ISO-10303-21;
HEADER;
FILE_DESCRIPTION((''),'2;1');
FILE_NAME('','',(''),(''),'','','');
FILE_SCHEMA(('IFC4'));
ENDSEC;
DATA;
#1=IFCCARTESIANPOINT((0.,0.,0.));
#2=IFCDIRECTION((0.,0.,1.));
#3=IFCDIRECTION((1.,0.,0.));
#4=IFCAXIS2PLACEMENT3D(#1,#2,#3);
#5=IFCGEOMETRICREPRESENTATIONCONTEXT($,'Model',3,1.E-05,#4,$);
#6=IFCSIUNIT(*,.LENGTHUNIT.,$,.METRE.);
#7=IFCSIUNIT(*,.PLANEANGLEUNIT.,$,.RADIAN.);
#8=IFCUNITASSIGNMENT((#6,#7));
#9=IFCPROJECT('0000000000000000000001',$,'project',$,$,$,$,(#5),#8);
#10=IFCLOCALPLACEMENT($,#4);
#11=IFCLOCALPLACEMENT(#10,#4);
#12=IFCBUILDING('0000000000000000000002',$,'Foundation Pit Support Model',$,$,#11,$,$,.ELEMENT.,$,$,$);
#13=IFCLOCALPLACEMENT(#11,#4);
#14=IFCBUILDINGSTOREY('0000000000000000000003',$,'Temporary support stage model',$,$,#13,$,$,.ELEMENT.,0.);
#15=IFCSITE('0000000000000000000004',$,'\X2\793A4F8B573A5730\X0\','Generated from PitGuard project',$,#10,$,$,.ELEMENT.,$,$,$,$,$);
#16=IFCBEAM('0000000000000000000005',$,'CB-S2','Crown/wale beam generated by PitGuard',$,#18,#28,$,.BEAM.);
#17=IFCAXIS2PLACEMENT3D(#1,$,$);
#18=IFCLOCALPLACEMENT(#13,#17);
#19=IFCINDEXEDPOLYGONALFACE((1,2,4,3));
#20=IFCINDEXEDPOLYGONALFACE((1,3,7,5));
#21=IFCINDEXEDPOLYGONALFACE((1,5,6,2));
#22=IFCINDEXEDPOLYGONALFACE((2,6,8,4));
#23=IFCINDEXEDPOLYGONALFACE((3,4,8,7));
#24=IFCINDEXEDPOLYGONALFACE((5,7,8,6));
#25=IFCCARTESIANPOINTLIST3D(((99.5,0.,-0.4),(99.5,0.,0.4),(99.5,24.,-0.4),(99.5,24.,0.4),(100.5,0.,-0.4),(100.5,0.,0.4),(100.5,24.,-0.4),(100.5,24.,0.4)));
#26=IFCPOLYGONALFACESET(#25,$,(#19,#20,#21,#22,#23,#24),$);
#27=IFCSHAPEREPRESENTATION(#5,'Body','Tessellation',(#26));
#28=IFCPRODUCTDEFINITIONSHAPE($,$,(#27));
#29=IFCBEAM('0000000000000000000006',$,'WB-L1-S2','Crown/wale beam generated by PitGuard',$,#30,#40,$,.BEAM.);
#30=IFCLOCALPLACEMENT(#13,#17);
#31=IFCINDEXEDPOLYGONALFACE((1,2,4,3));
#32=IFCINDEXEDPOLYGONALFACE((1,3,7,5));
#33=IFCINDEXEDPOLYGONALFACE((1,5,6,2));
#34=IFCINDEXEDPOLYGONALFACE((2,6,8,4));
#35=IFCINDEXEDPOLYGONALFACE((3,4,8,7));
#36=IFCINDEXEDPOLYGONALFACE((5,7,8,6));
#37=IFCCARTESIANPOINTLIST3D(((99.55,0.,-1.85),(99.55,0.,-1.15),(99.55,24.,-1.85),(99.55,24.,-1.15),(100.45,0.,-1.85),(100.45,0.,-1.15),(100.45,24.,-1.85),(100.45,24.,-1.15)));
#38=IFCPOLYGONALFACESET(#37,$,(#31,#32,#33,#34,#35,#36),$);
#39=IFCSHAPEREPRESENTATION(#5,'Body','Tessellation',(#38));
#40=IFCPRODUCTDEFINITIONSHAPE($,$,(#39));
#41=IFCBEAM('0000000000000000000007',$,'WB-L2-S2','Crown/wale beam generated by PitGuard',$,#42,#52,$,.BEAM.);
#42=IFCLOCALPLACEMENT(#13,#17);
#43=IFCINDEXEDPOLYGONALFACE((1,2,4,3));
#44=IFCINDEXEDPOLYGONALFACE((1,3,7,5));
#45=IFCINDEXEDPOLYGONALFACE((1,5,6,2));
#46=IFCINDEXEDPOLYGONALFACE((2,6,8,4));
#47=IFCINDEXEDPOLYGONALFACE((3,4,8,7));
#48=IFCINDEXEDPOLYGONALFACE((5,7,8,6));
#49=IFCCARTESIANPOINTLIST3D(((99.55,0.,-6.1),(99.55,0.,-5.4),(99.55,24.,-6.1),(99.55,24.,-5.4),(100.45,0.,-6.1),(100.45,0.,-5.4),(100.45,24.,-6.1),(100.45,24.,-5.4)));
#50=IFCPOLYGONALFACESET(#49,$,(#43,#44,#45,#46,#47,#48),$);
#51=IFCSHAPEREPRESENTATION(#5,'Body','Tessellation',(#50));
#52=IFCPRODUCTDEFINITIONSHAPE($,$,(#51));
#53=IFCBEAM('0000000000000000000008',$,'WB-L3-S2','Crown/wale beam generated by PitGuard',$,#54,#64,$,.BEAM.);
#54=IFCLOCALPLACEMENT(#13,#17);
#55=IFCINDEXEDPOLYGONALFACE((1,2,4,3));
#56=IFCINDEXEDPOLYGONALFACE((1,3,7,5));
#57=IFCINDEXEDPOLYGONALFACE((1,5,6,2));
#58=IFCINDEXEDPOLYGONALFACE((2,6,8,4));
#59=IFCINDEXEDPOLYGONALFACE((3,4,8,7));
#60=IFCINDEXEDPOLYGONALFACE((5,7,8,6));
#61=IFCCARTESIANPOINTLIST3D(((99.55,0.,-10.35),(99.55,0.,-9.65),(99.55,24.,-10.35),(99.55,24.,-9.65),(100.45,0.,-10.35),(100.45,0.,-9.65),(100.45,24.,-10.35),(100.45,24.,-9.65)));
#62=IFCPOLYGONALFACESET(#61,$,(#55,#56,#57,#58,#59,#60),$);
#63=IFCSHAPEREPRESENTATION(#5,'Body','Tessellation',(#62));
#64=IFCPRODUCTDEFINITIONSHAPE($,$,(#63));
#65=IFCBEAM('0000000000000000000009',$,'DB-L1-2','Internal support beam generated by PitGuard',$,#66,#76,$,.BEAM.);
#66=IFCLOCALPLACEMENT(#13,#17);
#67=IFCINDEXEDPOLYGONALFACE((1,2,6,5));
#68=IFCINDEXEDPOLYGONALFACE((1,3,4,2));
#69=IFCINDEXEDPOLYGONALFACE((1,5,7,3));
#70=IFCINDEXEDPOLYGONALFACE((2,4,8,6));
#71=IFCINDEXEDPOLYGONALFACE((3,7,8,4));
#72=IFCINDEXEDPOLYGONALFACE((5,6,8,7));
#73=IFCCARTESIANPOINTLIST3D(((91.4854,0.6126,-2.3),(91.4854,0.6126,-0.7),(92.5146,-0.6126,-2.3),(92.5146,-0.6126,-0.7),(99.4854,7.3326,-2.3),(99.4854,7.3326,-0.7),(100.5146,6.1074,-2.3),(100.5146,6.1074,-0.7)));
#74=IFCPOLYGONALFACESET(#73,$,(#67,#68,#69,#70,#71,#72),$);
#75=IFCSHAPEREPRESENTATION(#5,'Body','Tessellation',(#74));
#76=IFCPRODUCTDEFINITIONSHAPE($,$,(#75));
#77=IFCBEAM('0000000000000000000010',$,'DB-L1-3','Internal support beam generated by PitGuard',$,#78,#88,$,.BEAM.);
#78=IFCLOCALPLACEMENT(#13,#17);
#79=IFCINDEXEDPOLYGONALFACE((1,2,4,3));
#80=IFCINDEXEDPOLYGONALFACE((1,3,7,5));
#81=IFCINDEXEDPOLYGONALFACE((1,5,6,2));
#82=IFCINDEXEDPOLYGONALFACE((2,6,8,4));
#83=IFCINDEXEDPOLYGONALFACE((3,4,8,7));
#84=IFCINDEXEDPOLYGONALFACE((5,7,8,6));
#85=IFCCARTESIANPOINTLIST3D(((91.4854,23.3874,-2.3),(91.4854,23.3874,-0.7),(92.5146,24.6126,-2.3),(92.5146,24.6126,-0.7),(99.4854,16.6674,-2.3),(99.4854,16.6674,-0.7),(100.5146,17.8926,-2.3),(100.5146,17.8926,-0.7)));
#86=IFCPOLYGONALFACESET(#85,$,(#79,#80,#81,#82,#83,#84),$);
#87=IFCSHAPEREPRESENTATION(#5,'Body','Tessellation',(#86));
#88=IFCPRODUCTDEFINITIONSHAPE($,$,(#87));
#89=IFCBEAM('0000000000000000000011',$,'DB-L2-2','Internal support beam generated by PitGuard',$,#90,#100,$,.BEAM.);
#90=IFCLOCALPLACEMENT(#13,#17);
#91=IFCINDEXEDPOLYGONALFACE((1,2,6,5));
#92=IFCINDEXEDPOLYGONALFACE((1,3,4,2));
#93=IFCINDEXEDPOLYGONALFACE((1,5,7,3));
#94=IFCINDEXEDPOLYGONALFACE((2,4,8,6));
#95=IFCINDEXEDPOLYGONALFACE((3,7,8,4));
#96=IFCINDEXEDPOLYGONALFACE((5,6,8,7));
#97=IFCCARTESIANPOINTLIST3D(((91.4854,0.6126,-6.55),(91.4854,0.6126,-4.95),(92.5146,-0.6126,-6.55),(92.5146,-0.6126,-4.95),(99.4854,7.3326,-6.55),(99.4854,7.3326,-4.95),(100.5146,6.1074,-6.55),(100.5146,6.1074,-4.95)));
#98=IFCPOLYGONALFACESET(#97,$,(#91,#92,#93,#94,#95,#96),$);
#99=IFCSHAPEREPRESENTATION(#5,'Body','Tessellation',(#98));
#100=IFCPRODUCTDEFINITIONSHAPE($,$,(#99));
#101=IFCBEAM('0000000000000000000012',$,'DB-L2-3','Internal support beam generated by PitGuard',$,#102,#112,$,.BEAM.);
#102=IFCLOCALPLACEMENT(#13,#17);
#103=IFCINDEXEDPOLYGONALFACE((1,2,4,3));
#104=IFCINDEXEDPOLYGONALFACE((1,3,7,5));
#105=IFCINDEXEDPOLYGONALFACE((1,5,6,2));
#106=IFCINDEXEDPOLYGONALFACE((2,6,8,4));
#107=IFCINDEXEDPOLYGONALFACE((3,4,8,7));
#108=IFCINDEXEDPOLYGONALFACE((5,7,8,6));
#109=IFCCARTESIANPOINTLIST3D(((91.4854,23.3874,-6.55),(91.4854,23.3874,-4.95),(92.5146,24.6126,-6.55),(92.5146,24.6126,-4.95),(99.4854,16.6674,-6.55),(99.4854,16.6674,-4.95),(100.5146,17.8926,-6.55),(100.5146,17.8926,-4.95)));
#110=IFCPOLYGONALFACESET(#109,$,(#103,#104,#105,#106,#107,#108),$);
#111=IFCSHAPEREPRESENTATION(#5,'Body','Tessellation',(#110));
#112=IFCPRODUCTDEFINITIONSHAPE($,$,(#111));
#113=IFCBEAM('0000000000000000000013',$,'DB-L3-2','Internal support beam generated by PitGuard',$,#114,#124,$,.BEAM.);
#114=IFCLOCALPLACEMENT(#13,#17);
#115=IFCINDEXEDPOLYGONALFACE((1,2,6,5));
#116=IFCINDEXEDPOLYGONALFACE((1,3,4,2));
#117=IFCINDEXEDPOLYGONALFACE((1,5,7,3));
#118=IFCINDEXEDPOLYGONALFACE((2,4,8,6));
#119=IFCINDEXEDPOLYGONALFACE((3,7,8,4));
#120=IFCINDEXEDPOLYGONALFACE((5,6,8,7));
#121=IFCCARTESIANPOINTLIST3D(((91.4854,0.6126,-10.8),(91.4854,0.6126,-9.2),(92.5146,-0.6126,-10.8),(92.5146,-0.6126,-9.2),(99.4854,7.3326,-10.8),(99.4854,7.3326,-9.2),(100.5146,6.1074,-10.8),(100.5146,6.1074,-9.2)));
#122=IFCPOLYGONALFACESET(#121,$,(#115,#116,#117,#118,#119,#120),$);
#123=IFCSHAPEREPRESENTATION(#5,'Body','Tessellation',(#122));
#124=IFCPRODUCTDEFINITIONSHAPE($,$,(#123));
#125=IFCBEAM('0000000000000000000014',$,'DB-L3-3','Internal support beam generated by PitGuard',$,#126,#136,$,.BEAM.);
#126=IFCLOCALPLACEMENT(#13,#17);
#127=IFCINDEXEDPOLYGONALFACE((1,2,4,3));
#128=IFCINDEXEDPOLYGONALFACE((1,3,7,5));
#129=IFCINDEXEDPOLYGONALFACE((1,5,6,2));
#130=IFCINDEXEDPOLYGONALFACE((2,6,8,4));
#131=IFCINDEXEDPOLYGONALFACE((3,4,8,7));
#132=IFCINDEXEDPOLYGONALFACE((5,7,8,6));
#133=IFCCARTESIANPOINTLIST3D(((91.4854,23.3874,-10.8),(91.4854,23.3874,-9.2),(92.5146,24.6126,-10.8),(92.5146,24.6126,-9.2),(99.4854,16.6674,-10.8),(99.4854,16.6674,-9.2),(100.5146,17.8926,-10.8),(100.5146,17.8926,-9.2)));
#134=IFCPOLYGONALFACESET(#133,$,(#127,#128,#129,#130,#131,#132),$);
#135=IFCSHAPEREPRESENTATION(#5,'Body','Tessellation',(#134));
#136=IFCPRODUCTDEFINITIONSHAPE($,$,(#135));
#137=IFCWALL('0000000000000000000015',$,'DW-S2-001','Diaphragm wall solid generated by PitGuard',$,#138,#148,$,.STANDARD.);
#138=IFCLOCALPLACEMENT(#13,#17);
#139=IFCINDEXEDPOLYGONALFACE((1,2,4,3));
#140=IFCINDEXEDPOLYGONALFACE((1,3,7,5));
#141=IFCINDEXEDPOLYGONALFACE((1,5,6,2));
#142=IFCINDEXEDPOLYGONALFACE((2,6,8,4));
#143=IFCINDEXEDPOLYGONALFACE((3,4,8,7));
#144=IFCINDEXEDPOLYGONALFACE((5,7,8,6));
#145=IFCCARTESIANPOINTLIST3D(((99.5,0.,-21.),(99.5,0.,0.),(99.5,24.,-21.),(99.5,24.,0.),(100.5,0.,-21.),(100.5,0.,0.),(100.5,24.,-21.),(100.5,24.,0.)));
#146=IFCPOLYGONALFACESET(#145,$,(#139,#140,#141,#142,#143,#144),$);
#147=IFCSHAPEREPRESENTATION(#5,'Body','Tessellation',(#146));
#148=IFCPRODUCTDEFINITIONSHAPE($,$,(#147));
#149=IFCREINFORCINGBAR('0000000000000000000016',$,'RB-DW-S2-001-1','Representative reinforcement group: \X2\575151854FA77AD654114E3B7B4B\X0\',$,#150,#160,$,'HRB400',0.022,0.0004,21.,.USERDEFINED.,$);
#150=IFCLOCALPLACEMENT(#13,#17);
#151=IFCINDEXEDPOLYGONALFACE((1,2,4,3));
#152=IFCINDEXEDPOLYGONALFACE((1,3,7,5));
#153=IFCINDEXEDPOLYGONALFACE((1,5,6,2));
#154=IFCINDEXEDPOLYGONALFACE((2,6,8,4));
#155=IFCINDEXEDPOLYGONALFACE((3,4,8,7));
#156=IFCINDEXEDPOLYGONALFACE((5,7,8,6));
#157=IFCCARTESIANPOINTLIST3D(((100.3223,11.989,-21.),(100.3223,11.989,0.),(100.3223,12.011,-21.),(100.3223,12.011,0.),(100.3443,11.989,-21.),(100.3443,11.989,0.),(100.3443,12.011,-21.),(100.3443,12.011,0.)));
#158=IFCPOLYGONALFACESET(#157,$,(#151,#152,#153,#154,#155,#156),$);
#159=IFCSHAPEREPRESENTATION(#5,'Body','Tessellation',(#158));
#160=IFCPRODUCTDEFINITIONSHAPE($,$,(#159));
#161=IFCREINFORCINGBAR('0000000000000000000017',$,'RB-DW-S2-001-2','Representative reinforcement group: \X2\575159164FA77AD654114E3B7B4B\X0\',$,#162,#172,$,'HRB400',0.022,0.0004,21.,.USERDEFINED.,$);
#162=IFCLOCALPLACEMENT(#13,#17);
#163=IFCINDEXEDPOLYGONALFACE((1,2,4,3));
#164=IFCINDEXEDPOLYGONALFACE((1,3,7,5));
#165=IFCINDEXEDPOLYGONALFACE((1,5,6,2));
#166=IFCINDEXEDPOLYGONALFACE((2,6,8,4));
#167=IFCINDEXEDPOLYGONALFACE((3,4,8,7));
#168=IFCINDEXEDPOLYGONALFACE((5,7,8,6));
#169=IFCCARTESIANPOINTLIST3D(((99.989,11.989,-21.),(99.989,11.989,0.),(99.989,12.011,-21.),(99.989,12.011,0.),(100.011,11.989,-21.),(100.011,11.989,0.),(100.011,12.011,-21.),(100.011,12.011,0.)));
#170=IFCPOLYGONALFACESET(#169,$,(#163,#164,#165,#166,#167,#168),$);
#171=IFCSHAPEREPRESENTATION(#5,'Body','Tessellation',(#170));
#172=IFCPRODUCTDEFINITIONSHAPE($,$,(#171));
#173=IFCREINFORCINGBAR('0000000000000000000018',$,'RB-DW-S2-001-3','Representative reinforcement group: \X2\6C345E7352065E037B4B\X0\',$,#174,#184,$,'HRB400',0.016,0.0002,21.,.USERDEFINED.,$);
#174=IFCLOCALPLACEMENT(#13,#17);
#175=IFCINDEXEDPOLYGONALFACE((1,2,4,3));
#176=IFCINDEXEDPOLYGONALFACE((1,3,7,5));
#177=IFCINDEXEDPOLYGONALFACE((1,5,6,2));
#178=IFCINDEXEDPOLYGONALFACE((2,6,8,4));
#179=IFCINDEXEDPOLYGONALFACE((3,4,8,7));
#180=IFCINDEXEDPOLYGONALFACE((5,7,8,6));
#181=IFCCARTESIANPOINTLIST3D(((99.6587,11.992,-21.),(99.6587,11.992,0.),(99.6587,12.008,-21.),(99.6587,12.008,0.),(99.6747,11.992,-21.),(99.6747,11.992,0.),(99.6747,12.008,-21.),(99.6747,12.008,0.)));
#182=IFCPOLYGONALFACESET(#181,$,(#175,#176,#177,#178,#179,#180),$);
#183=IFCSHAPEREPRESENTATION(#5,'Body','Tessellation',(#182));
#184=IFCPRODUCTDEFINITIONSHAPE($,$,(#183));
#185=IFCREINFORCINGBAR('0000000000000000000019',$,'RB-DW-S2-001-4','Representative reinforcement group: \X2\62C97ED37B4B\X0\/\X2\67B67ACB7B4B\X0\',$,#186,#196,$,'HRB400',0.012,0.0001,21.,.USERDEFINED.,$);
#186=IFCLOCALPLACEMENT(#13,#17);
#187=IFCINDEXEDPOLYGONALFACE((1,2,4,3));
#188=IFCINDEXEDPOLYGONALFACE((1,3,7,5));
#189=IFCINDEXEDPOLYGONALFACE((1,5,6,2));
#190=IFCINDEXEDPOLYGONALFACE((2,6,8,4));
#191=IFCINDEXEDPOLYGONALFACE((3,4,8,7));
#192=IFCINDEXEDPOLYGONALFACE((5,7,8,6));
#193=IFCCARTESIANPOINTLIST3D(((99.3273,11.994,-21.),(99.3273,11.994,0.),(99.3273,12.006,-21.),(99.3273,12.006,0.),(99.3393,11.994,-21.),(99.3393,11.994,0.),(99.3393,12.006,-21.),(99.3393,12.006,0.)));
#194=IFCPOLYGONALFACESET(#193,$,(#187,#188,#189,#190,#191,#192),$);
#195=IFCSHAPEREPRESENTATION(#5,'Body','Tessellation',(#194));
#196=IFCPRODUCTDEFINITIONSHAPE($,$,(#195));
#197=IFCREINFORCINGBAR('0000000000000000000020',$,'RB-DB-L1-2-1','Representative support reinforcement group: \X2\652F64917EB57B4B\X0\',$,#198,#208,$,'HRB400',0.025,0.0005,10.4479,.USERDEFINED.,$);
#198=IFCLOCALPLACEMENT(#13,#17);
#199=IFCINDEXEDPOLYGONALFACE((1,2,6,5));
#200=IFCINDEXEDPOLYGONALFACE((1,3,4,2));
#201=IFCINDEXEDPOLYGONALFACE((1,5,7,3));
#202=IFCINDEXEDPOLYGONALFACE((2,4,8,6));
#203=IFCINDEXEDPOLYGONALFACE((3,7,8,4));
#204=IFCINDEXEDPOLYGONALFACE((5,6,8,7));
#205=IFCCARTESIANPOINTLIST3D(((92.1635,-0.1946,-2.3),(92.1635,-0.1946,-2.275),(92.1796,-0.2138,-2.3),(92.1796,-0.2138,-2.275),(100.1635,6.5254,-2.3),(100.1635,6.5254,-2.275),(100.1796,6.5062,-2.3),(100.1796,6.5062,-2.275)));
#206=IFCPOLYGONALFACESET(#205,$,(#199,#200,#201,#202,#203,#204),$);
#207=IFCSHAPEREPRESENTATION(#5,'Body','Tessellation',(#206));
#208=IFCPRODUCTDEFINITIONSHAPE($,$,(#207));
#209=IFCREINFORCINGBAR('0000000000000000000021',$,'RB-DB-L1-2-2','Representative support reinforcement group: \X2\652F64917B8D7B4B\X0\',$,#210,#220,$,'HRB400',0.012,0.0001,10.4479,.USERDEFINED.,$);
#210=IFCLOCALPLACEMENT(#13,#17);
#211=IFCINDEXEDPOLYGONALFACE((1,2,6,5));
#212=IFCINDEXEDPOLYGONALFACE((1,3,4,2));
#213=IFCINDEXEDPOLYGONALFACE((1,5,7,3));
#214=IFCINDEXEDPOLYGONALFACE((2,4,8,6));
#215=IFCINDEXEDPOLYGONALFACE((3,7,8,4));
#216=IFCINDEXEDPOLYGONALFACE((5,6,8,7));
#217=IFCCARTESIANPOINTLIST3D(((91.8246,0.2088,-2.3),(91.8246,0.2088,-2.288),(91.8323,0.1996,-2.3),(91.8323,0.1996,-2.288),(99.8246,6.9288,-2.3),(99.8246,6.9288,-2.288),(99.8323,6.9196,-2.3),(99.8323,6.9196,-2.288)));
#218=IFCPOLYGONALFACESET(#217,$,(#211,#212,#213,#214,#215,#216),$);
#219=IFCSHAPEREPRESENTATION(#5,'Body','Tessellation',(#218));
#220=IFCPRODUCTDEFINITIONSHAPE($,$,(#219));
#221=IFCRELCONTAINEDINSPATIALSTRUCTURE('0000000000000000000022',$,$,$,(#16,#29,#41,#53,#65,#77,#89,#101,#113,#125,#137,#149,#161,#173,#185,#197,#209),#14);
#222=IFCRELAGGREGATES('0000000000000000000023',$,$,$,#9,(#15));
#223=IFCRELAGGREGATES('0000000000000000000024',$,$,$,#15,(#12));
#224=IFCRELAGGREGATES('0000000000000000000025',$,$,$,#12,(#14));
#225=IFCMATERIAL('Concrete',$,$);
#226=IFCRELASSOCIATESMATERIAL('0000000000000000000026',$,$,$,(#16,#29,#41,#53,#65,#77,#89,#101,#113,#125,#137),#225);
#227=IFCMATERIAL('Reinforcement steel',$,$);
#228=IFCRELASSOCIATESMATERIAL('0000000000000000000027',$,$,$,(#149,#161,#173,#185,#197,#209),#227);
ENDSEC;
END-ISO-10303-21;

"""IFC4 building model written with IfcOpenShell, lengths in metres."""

from ifc_helpers import new_model, si_unit, frame, origin_with_axes, origin_2d, place, context, project, spatial, rectangle, extrude, material, element, save


model = new_model("IFC4")

# Units and contexts
model_context = context("Model", 3, precision=1e-05, world=origin_with_axes())
ifc_project = project(units=[si_unit("LENGTHUNIT", "METRE"), si_unit("PLANEANGLEUNIT", "RADIAN")], contexts=[model_context])

# Site, building, storey
site_placement = place(None, origin_with_axes())
site = spatial("IfcSite", under=ifc_project, at=site_placement, Name="示例场地", Description="Generated from PitGuard project", CompositionType="ELEMENT")
building_placement = place(site_placement, origin_with_axes())
building = spatial("IfcBuilding", under=site, at=building_placement, Name="Foundation Pit Support Model", CompositionType="ELEMENT")
storey_placement = place(building_placement, origin_with_axes())
storey = spatial("IfcBuildingStorey", under=building, at=storey_placement, Name="Temporary support stage model", CompositionType="ELEMENT", Elevation=0.0)

# Beams
ifc_material_1 = material(Name="Concrete")
beam_placement = place(storey_placement, frame((100.0, 12.0, -0.4), z_axis=(0.0, 0.0, 1.0), x_axis=(0.0, 1.0, 0.0)))
element("IfcBeam", 1, at=beam_placement, inside=storey, material=ifc_material_1, Name="CB-S2", Description="Crown/wale beam generated by PitGuard", PredefinedType="BEAM", context=model_context, shape_type="SweptSolid", body=[
    extrude(rectangle(XDim=24.0, YDim=1.0, at=origin_2d()), origin_with_axes(), (0.0, 0.0, 1.0), 0.8),
])
for number, where, z_axis, x_axis, name in (
    (2, (100.0, 12.0, -1.85), (0.0, 0.0, 1.0), (0.0, 1.0, 0.0), "WB-L1-S2"),
    (3, (100.0, 12.0, -6.1), (0.0, 0.0, 1.0), (0.0, 1.0, 0.0), "WB-L2-S2"),
    (4, (100.0, 12.0, -10.35), (0.0, 0.0, 1.0), (0.0, 1.0, 0.0), "WB-L3-S2"),
):
    element("IfcBeam", number, at=place(storey_placement, frame(where, z_axis=z_axis, x_axis=x_axis)), inside=storey, material=ifc_material_1, Name=name, Description="Crown/wale beam generated by PitGuard", PredefinedType="BEAM", context=model_context, shape_type="SweptSolid", body=[
        extrude(rectangle(XDim=24.0, YDim=0.9, at=origin_2d()), origin_with_axes(), (0.0, 0.0, 1.0), 0.7),
    ])
for number, where, z_axis, x_axis, name in (
    (5, (96.0, 3.36, -2.3), (0.0, 0.0, 1.0), (0.765705, 0.643192, 0.0), "DB-L1-2"),
    (6, (96.0, 20.64, -2.3), (0.0, 0.0, 1.0), (0.765705, -0.643192, 0.0), "DB-L1-3"),
    (7, (96.0, 3.36, -6.55), (0.0, 0.0, 1.0), (0.765705, 0.643192, 0.0), "DB-L2-2"),
    (8, (96.0, 20.64, -6.55), (0.0, 0.0, 1.0), (0.765705, -0.643192, 0.0), "DB-L2-3"),
    (9, (96.0, 3.36, -10.8), (0.0, 0.0, 1.0), (0.765705, 0.643192, 0.0), "DB-L3-2"),
    (10, (96.0, 20.64, -10.8), (0.0, 0.0, 1.0), (0.765705, -0.643192, 0.0), "DB-L3-3"),
):
    element("IfcBeam", number, at=place(storey_placement, frame(where, z_axis=z_axis, x_axis=x_axis)), inside=storey, material=ifc_material_1, Name=name, Description="Internal support beam generated by PitGuard", PredefinedType="BEAM", context=model_context, shape_type="SweptSolid", body=[
        extrude(rectangle(XDim=10.4479, YDim=1.6, at=origin_2d()), origin_with_axes(), (0.0, 0.0, 1.0), 1.6),
    ])

# Wall
wall_placement = place(storey_placement, frame((100.0, 12.0, -21.0), z_axis=(0.0, 0.0, 1.0), x_axis=(0.0, 1.0, 0.0)))
element("IfcWall", 11, at=wall_placement, inside=storey, material=ifc_material_1, Name="DW-S2-001", Description="Diaphragm wall solid generated by PitGuard", PredefinedType="STANDARD", context=model_context, shape_type="SweptSolid", body=[
    extrude(rectangle(XDim=24.0, YDim=1.0, at=origin_2d()), origin_with_axes(), (0.0, 0.0, 1.0), 21.0),
])

# Reinforcing bars
ifc_material_2 = material(Name="Reinforcement steel")
for number, where, z_axis, x_axis, name, description in (
    (12, (100.3333, 12.0, -21.0), (0.0, 0.0, 1.0), (1.0, 0.0, 0.0), "RB-DW-S2-001-1", "Representative reinforcement group: 坑内侧竖向主筋"),
    (13, (100.0, 12.0, -21.0), (0.0, 0.0, 1.0), (1.0, 0.0, 0.0), "RB-DW-S2-001-2", "Representative reinforcement group: 坑外侧竖向主筋"),
):
    element("IfcReinforcingBar", number, at=place(storey_placement, frame(where, z_axis=z_axis, x_axis=x_axis)), inside=storey, material=ifc_material_2, Name=name, Description=description, SteelGrade="HRB400", BarLength=21.0, CrossSectionArea=0.0004, NominalDiameter=0.022, PredefinedType="USERDEFINED", context=model_context, shape_type="SweptSolid", body=[
        extrude(rectangle(XDim=0.022, YDim=0.022, at=origin_2d()), origin_with_axes(), (0.0, 0.0, 1.0), 21.0),
    ])
reinforcing_bar_1_placement = place(storey_placement, frame((99.6667, 12.0, -21.0), z_axis=(0.0, 0.0, 1.0), x_axis=(1.0, 0.0, 0.0)))
element("IfcReinforcingBar", 14, at=reinforcing_bar_1_placement, inside=storey, material=ifc_material_2, Name="RB-DW-S2-001-3", Description="Representative reinforcement group: 水平分布筋", SteelGrade="HRB400", BarLength=21.0, CrossSectionArea=0.0002, NominalDiameter=0.016, PredefinedType="USERDEFINED", context=model_context, shape_type="SweptSolid", body=[
    extrude(rectangle(XDim=0.016, YDim=0.016, at=origin_2d()), origin_with_axes(), (0.0, 0.0, 1.0), 21.0),
])
reinforcing_bar_2_placement = place(storey_placement, frame((99.3333, 12.0, -21.0), z_axis=(0.0, 0.0, 1.0), x_axis=(1.0, 0.0, 0.0)))
element("IfcReinforcingBar", 15, at=reinforcing_bar_2_placement, inside=storey, material=ifc_material_2, Name="RB-DW-S2-001-4", Description="Representative reinforcement group: 拉结筋/架立筋", SteelGrade="HRB400", BarLength=21.0, CrossSectionArea=0.0001, NominalDiameter=0.012, PredefinedType="USERDEFINED", context=model_context, shape_type="SweptSolid", body=[
    extrude(rectangle(XDim=0.012, YDim=0.012, at=origin_2d()), origin_with_axes(), (0.0, 0.0, 1.0), 21.0),
])
reinforcing_bar_3_placement = place(storey_placement, frame((96.1715, 3.1558, -2.3), z_axis=(0.0, 0.0, 1.0), x_axis=(0.765705, 0.643192, 0.0)))
element("IfcReinforcingBar", 16, at=reinforcing_bar_3_placement, inside=storey, material=ifc_material_2, Name="RB-DB-L1-2-1", Description="Representative support reinforcement group: 支撑纵筋", SteelGrade="HRB400", BarLength=10.4479, CrossSectionArea=0.0005, NominalDiameter=0.025, PredefinedType="USERDEFINED", context=model_context, shape_type="SweptSolid", body=[
    extrude(rectangle(XDim=10.4479, YDim=0.025, at=origin_2d()), origin_with_axes(), (0.0, 0.0, 1.0), 0.025),
])
reinforcing_bar_4_placement = place(storey_placement, frame((95.8285, 3.5642, -2.3), z_axis=(0.0, 0.0, 1.0), x_axis=(0.765705, 0.643192, 0.0)))
element("IfcReinforcingBar", 17, at=reinforcing_bar_4_placement, inside=storey, material=ifc_material_2, Name="RB-DB-L1-2-2", Description="Representative support reinforcement group: 支撑箍筋", SteelGrade="HRB400", BarLength=10.4479, CrossSectionArea=0.0001, NominalDiameter=0.012, PredefinedType="USERDEFINED", context=model_context, shape_type="SweptSolid", body=[
    extrude(rectangle(XDim=10.4479, YDim=0.012, at=origin_2d()), origin_with_axes(), (0.0, 0.0, 1.0), 0.012),
])

save(model, "model.ifc")
